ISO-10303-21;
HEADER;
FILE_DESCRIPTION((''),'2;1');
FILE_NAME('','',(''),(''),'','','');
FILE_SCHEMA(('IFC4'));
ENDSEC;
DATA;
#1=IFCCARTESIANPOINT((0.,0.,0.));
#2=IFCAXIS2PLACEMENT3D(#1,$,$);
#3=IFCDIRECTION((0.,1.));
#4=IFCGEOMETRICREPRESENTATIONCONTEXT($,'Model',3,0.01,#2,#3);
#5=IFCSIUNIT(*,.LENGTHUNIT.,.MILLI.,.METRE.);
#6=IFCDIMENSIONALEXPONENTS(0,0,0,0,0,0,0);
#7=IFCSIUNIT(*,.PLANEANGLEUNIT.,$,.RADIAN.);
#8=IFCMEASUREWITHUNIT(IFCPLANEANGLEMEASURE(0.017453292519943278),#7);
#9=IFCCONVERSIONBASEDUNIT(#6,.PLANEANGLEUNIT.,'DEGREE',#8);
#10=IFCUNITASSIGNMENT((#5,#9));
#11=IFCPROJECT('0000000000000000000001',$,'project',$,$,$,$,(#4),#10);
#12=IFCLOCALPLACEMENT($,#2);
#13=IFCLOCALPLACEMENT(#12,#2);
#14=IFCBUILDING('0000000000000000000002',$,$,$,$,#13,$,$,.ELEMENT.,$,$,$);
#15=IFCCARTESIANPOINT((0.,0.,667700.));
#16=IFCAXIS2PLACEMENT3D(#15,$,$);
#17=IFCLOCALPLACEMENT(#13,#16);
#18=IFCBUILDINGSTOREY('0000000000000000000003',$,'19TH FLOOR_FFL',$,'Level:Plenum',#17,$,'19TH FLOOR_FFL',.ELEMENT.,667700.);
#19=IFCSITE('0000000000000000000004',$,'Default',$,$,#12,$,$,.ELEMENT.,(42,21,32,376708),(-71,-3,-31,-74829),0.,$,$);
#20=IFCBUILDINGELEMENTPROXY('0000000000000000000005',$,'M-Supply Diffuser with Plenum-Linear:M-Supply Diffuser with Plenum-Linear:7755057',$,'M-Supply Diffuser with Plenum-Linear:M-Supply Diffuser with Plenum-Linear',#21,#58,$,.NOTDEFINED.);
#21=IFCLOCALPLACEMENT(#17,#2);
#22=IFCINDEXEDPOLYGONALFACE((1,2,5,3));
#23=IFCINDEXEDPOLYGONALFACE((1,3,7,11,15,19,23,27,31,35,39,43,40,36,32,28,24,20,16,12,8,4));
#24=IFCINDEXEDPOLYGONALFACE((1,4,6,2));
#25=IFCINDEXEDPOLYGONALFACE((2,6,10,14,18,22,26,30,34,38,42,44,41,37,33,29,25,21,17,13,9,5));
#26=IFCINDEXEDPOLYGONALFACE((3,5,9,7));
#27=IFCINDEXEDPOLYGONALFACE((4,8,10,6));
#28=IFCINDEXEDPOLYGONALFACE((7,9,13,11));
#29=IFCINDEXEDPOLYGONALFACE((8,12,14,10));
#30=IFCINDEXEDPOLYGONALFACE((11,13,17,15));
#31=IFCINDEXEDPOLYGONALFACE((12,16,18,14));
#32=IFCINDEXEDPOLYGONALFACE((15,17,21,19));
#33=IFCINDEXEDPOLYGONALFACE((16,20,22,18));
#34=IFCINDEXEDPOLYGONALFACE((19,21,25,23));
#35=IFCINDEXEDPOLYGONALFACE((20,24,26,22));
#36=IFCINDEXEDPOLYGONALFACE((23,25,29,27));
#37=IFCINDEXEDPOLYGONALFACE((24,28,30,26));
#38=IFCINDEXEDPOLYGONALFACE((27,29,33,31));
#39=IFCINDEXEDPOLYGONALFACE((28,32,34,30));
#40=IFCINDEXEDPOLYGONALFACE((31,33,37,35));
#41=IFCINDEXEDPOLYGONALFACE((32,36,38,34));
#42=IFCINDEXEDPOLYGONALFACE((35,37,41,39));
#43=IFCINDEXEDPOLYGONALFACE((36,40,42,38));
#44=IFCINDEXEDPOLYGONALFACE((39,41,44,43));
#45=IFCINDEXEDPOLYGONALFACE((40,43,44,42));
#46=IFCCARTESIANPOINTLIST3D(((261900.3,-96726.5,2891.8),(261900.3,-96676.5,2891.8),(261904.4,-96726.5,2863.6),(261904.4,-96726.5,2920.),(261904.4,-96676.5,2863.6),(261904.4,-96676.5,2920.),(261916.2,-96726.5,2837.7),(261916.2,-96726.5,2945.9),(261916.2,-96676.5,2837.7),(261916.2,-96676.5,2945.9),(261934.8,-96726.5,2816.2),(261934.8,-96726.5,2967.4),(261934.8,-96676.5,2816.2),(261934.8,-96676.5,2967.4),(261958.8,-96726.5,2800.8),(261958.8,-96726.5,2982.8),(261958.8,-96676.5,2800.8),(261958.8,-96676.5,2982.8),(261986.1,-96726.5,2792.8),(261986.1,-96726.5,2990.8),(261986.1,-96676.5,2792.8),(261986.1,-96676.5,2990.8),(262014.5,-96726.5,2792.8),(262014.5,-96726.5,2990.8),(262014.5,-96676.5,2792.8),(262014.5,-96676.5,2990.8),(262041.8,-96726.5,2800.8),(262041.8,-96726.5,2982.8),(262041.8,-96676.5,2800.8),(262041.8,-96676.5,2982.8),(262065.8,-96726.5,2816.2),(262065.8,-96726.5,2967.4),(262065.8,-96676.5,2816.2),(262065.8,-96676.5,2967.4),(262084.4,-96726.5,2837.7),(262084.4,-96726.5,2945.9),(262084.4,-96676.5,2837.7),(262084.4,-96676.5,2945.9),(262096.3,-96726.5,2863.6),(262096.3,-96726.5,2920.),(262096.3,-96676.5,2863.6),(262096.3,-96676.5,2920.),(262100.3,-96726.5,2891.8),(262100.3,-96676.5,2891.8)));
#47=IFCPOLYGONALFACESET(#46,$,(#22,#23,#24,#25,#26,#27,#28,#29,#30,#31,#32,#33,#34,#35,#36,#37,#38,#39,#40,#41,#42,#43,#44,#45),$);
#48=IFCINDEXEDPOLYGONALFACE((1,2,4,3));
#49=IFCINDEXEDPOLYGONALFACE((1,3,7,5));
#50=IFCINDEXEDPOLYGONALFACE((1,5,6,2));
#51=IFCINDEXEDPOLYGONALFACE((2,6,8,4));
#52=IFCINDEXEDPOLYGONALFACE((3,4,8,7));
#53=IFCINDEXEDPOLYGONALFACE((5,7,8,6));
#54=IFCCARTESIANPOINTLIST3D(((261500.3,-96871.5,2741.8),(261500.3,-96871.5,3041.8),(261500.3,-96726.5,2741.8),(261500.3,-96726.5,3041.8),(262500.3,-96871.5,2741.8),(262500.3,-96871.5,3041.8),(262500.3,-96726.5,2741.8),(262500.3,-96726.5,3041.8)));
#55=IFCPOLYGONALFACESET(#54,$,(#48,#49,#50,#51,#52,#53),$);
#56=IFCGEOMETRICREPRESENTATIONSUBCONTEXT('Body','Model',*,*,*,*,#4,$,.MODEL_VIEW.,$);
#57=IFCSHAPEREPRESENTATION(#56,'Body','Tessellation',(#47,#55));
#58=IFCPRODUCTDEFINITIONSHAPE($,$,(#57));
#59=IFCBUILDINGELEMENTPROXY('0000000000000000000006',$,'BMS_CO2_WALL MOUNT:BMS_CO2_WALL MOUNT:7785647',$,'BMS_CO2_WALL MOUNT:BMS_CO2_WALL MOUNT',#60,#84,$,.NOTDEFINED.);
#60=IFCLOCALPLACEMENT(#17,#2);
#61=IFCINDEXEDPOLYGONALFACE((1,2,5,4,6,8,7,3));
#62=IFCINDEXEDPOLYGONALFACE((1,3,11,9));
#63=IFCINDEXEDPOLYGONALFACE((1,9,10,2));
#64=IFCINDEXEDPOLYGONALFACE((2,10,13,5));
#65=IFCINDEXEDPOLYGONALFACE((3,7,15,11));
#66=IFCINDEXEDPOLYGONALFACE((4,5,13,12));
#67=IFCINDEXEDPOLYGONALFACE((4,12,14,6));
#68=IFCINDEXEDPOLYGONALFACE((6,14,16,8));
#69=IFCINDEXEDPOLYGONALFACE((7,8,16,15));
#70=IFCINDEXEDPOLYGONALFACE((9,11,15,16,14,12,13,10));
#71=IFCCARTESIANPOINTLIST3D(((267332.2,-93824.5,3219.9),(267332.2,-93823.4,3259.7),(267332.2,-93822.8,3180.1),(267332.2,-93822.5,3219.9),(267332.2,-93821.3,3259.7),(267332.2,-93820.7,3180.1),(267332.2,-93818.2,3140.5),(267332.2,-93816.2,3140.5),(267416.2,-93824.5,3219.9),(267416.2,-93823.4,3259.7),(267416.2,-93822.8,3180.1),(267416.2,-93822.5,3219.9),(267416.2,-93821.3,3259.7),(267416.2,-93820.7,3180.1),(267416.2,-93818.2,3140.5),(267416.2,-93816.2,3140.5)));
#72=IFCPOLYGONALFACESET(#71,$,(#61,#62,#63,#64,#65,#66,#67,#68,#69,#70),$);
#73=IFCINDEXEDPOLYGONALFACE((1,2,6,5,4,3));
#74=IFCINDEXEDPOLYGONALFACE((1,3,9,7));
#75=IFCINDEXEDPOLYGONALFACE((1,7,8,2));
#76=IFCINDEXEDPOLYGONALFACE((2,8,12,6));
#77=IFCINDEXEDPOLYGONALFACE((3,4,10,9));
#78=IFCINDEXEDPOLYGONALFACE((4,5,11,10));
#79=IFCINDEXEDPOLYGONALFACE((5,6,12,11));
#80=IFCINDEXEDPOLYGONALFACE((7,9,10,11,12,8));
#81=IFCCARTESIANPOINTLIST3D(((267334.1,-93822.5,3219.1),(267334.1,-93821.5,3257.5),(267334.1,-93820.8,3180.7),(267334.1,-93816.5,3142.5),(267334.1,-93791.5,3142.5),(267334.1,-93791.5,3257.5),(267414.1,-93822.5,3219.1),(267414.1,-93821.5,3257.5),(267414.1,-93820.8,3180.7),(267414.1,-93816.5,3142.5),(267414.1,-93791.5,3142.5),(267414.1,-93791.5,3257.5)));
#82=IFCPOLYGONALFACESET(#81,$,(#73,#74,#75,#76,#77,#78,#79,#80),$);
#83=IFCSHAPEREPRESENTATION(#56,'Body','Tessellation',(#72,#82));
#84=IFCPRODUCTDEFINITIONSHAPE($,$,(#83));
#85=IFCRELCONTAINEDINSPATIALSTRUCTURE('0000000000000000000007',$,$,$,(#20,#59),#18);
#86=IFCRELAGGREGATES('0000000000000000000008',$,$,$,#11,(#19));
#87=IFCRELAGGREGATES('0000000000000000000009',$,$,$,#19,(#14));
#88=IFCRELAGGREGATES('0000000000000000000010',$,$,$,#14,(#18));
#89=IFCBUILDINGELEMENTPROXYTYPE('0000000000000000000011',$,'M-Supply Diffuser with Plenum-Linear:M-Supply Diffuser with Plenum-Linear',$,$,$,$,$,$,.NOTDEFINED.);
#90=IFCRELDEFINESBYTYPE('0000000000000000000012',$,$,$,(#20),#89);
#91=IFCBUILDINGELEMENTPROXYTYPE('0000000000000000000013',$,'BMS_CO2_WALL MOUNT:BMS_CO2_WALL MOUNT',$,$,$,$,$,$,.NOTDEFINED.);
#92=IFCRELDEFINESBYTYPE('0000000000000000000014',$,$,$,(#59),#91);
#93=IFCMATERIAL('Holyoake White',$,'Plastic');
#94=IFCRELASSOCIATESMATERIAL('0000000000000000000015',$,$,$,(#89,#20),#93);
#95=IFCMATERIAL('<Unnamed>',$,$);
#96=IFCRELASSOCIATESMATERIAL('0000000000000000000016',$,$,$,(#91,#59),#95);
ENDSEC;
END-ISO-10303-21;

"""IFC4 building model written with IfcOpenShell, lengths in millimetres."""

from ifc_helpers import new_model, entity, si_unit, converted_unit, direction, frame, origin, place, context, subcontext, project, spatial, line, arc, indexed_curve, outline, extrude, source, transform, mapped, material, type_object, type_shapes, element, save


model = new_model("IFC4")

# Units and contexts
model_context = context("Model", 3, precision=0.01, world=origin(), true_north=direction((0.0, 1.0)))
body_context = subcontext(model_context, "Body", "Model", "MODEL_VIEW")
ifc_project = project(units=[si_unit("LENGTHUNIT", "METRE", prefix="MILLI"), converted_unit("PLANEANGLEUNIT", "DEGREE", entity("IfcPlaneAngleMeasure", 0.017453292519943278), si_unit("PLANEANGLEUNIT", "RADIAN"), dimensions=[0, 0, 0, 0, 0, 0, 0])], contexts=[model_context])

# Site, building, storey
site_placement = place(None, origin())
site = spatial("IfcSite", under=ifc_project, at=site_placement, Name="Default", CompositionType="ELEMENT", RefLatitude=(42, 21, 32, 376708), RefLongitude=(-71, -3, -31, -74829), RefElevation=0.0)
building_placement = place(site_placement, origin())
building = spatial("IfcBuilding", under=site, at=building_placement, CompositionType="ELEMENT")
storey_placement = place(building_placement, frame((0.0, 0.0, 667700.0)))
storey = spatial("IfcBuildingStorey", under=building, at=storey_placement, Name="19TH FLOOR_FFL", ObjectType="Level:Plenum", LongName="19TH FLOOR_FFL", CompositionType="ELEMENT", Elevation=667700.0)

# Shared definitions
ifc_material_1 = material(Name="<Unnamed>")

# Building element proxies
ifc_material_2 = material(Name="Holyoake White", Category="Plastic")
building_element_proxy_type_1 = type_object("IfcBuildingElementProxyType", Name="M-Supply Diffuser with Plenum-Linear:M-Supply Diffuser with Plenum-Linear", PredefinedType="NOTDEFINED", material=ifc_material_2)
shared_shape_1 = source(origin(), body_context, "Body", "SweptSolid", [
    extrude(outline(indexed_curve([(-100.0, 0.0), (0.0, -100.0), (100.0, 0.0), (0.0, 100.0)], segments=[arc(1, 2, 3), arc(3, 4, 1)], self_intersect=False)), frame((0.0, -122.5, 195.0), z_axis=(0.0, 1.0, 0.0), x_axis=(1.0, 0.0, 0.0)), (0.0, 0.0, 1.0), 50.0),
    extrude(outline(indexed_curve([(-500.0, -72.5), (500.0, -72.5), (500.0, 72.5), (-500.0, 72.5), (-500.0, -72.5)], self_intersect=False)), frame((0.0, 0.0, 45.0), z_axis=(0.0, 0.0, 1.0), x_axis=(-1.0, 0.0, 0.0)), (0.0, 0.0, 1.0), 300.0),
])
type_shapes(building_element_proxy_type_1, [shared_shape_1])
for number, where, z_axis, x_axis, name in (
    (1, (262000.3, -96799.0, 2696.8), (0.0, 0.0, 1.0), (-1.0, 0.0, 0.0), "M-Supply Diffuser with Plenum-Linear:M-Supply Diffuser with Plenum-Linear:7755057"),
):
    element("IfcBuildingElementProxy", number, at=place(storey_placement, frame(where, z_axis=z_axis, x_axis=x_axis)), inside=storey, type_object=building_element_proxy_type_1, material=ifc_material_2, Name=name, ObjectType="M-Supply Diffuser with Plenum-Linear:M-Supply Diffuser with Plenum-Linear", PredefinedType="NOTDEFINED", context=body_context, shape_type="MappedRepresentation", body=[
        mapped(shared_shape_1, transform((0.0, 0.0, 0.0), scale=1.0)),
    ])
building_element_proxy_type_2 = type_object("IfcBuildingElementProxyType", Name="BMS_CO2_WALL MOUNT:BMS_CO2_WALL MOUNT", PredefinedType="NOTDEFINED", material=ifc_material_1)
shared_shape_2 = source(origin(), body_context, "Body", "SweptSolid", [
    extrude(outline(indexed_curve([(-59.6, -1.6), (-59.6, -3.6), (0.1, -4.2), (59.6, 1.6), (59.6, 3.6), (0.1, -2.2)], segments=[line(1, 2), arc(2, 3, 4), line(4, 5), arc(5, 6, 1)], self_intersect=False)), frame((-42.0, -0.1, 28.3), z_axis=(-1.0, 0.0, 0.0), x_axis=(0.0, 1.0, 0.0)), (0.0, 0.0, -1.0), 84.0),
    extrude(outline(indexed_curve([(-13.7, -57.5), (11.3, -57.5), (16.7, -0.1), (16.2, 57.5), (-13.7, 57.5)], segments=[line(1, 2), arc(2, 3, 4), line(4, 5, 1)], self_intersect=False)), frame((-40.0, 0.0, 13.7), z_axis=(1.0, 0.0, 0.0), x_axis=(0.0, 0.0, 1.0)), (0.0, 0.0, 1.0), 80.0),
])
type_shapes(building_element_proxy_type_2, [shared_shape_2])
proxy_1_placement = place(storey_placement, frame((267374.1, -93791.5, 3200.0), z_axis=(0.0, -1.0, 0.0), x_axis=(-1.0, 0.0, 0.0)))
element("IfcBuildingElementProxy", 2, at=proxy_1_placement, inside=storey, type_object=building_element_proxy_type_2, material=ifc_material_1, Name="BMS_CO2_WALL MOUNT:BMS_CO2_WALL MOUNT:7785647", ObjectType="BMS_CO2_WALL MOUNT:BMS_CO2_WALL MOUNT", PredefinedType="NOTDEFINED", context=body_context, shape_type="MappedRepresentation", body=[
    mapped(shared_shape_2, transform((0.0, 0.0, 0.0), scale=1.0)),
])

save(model, "model.ifc")
